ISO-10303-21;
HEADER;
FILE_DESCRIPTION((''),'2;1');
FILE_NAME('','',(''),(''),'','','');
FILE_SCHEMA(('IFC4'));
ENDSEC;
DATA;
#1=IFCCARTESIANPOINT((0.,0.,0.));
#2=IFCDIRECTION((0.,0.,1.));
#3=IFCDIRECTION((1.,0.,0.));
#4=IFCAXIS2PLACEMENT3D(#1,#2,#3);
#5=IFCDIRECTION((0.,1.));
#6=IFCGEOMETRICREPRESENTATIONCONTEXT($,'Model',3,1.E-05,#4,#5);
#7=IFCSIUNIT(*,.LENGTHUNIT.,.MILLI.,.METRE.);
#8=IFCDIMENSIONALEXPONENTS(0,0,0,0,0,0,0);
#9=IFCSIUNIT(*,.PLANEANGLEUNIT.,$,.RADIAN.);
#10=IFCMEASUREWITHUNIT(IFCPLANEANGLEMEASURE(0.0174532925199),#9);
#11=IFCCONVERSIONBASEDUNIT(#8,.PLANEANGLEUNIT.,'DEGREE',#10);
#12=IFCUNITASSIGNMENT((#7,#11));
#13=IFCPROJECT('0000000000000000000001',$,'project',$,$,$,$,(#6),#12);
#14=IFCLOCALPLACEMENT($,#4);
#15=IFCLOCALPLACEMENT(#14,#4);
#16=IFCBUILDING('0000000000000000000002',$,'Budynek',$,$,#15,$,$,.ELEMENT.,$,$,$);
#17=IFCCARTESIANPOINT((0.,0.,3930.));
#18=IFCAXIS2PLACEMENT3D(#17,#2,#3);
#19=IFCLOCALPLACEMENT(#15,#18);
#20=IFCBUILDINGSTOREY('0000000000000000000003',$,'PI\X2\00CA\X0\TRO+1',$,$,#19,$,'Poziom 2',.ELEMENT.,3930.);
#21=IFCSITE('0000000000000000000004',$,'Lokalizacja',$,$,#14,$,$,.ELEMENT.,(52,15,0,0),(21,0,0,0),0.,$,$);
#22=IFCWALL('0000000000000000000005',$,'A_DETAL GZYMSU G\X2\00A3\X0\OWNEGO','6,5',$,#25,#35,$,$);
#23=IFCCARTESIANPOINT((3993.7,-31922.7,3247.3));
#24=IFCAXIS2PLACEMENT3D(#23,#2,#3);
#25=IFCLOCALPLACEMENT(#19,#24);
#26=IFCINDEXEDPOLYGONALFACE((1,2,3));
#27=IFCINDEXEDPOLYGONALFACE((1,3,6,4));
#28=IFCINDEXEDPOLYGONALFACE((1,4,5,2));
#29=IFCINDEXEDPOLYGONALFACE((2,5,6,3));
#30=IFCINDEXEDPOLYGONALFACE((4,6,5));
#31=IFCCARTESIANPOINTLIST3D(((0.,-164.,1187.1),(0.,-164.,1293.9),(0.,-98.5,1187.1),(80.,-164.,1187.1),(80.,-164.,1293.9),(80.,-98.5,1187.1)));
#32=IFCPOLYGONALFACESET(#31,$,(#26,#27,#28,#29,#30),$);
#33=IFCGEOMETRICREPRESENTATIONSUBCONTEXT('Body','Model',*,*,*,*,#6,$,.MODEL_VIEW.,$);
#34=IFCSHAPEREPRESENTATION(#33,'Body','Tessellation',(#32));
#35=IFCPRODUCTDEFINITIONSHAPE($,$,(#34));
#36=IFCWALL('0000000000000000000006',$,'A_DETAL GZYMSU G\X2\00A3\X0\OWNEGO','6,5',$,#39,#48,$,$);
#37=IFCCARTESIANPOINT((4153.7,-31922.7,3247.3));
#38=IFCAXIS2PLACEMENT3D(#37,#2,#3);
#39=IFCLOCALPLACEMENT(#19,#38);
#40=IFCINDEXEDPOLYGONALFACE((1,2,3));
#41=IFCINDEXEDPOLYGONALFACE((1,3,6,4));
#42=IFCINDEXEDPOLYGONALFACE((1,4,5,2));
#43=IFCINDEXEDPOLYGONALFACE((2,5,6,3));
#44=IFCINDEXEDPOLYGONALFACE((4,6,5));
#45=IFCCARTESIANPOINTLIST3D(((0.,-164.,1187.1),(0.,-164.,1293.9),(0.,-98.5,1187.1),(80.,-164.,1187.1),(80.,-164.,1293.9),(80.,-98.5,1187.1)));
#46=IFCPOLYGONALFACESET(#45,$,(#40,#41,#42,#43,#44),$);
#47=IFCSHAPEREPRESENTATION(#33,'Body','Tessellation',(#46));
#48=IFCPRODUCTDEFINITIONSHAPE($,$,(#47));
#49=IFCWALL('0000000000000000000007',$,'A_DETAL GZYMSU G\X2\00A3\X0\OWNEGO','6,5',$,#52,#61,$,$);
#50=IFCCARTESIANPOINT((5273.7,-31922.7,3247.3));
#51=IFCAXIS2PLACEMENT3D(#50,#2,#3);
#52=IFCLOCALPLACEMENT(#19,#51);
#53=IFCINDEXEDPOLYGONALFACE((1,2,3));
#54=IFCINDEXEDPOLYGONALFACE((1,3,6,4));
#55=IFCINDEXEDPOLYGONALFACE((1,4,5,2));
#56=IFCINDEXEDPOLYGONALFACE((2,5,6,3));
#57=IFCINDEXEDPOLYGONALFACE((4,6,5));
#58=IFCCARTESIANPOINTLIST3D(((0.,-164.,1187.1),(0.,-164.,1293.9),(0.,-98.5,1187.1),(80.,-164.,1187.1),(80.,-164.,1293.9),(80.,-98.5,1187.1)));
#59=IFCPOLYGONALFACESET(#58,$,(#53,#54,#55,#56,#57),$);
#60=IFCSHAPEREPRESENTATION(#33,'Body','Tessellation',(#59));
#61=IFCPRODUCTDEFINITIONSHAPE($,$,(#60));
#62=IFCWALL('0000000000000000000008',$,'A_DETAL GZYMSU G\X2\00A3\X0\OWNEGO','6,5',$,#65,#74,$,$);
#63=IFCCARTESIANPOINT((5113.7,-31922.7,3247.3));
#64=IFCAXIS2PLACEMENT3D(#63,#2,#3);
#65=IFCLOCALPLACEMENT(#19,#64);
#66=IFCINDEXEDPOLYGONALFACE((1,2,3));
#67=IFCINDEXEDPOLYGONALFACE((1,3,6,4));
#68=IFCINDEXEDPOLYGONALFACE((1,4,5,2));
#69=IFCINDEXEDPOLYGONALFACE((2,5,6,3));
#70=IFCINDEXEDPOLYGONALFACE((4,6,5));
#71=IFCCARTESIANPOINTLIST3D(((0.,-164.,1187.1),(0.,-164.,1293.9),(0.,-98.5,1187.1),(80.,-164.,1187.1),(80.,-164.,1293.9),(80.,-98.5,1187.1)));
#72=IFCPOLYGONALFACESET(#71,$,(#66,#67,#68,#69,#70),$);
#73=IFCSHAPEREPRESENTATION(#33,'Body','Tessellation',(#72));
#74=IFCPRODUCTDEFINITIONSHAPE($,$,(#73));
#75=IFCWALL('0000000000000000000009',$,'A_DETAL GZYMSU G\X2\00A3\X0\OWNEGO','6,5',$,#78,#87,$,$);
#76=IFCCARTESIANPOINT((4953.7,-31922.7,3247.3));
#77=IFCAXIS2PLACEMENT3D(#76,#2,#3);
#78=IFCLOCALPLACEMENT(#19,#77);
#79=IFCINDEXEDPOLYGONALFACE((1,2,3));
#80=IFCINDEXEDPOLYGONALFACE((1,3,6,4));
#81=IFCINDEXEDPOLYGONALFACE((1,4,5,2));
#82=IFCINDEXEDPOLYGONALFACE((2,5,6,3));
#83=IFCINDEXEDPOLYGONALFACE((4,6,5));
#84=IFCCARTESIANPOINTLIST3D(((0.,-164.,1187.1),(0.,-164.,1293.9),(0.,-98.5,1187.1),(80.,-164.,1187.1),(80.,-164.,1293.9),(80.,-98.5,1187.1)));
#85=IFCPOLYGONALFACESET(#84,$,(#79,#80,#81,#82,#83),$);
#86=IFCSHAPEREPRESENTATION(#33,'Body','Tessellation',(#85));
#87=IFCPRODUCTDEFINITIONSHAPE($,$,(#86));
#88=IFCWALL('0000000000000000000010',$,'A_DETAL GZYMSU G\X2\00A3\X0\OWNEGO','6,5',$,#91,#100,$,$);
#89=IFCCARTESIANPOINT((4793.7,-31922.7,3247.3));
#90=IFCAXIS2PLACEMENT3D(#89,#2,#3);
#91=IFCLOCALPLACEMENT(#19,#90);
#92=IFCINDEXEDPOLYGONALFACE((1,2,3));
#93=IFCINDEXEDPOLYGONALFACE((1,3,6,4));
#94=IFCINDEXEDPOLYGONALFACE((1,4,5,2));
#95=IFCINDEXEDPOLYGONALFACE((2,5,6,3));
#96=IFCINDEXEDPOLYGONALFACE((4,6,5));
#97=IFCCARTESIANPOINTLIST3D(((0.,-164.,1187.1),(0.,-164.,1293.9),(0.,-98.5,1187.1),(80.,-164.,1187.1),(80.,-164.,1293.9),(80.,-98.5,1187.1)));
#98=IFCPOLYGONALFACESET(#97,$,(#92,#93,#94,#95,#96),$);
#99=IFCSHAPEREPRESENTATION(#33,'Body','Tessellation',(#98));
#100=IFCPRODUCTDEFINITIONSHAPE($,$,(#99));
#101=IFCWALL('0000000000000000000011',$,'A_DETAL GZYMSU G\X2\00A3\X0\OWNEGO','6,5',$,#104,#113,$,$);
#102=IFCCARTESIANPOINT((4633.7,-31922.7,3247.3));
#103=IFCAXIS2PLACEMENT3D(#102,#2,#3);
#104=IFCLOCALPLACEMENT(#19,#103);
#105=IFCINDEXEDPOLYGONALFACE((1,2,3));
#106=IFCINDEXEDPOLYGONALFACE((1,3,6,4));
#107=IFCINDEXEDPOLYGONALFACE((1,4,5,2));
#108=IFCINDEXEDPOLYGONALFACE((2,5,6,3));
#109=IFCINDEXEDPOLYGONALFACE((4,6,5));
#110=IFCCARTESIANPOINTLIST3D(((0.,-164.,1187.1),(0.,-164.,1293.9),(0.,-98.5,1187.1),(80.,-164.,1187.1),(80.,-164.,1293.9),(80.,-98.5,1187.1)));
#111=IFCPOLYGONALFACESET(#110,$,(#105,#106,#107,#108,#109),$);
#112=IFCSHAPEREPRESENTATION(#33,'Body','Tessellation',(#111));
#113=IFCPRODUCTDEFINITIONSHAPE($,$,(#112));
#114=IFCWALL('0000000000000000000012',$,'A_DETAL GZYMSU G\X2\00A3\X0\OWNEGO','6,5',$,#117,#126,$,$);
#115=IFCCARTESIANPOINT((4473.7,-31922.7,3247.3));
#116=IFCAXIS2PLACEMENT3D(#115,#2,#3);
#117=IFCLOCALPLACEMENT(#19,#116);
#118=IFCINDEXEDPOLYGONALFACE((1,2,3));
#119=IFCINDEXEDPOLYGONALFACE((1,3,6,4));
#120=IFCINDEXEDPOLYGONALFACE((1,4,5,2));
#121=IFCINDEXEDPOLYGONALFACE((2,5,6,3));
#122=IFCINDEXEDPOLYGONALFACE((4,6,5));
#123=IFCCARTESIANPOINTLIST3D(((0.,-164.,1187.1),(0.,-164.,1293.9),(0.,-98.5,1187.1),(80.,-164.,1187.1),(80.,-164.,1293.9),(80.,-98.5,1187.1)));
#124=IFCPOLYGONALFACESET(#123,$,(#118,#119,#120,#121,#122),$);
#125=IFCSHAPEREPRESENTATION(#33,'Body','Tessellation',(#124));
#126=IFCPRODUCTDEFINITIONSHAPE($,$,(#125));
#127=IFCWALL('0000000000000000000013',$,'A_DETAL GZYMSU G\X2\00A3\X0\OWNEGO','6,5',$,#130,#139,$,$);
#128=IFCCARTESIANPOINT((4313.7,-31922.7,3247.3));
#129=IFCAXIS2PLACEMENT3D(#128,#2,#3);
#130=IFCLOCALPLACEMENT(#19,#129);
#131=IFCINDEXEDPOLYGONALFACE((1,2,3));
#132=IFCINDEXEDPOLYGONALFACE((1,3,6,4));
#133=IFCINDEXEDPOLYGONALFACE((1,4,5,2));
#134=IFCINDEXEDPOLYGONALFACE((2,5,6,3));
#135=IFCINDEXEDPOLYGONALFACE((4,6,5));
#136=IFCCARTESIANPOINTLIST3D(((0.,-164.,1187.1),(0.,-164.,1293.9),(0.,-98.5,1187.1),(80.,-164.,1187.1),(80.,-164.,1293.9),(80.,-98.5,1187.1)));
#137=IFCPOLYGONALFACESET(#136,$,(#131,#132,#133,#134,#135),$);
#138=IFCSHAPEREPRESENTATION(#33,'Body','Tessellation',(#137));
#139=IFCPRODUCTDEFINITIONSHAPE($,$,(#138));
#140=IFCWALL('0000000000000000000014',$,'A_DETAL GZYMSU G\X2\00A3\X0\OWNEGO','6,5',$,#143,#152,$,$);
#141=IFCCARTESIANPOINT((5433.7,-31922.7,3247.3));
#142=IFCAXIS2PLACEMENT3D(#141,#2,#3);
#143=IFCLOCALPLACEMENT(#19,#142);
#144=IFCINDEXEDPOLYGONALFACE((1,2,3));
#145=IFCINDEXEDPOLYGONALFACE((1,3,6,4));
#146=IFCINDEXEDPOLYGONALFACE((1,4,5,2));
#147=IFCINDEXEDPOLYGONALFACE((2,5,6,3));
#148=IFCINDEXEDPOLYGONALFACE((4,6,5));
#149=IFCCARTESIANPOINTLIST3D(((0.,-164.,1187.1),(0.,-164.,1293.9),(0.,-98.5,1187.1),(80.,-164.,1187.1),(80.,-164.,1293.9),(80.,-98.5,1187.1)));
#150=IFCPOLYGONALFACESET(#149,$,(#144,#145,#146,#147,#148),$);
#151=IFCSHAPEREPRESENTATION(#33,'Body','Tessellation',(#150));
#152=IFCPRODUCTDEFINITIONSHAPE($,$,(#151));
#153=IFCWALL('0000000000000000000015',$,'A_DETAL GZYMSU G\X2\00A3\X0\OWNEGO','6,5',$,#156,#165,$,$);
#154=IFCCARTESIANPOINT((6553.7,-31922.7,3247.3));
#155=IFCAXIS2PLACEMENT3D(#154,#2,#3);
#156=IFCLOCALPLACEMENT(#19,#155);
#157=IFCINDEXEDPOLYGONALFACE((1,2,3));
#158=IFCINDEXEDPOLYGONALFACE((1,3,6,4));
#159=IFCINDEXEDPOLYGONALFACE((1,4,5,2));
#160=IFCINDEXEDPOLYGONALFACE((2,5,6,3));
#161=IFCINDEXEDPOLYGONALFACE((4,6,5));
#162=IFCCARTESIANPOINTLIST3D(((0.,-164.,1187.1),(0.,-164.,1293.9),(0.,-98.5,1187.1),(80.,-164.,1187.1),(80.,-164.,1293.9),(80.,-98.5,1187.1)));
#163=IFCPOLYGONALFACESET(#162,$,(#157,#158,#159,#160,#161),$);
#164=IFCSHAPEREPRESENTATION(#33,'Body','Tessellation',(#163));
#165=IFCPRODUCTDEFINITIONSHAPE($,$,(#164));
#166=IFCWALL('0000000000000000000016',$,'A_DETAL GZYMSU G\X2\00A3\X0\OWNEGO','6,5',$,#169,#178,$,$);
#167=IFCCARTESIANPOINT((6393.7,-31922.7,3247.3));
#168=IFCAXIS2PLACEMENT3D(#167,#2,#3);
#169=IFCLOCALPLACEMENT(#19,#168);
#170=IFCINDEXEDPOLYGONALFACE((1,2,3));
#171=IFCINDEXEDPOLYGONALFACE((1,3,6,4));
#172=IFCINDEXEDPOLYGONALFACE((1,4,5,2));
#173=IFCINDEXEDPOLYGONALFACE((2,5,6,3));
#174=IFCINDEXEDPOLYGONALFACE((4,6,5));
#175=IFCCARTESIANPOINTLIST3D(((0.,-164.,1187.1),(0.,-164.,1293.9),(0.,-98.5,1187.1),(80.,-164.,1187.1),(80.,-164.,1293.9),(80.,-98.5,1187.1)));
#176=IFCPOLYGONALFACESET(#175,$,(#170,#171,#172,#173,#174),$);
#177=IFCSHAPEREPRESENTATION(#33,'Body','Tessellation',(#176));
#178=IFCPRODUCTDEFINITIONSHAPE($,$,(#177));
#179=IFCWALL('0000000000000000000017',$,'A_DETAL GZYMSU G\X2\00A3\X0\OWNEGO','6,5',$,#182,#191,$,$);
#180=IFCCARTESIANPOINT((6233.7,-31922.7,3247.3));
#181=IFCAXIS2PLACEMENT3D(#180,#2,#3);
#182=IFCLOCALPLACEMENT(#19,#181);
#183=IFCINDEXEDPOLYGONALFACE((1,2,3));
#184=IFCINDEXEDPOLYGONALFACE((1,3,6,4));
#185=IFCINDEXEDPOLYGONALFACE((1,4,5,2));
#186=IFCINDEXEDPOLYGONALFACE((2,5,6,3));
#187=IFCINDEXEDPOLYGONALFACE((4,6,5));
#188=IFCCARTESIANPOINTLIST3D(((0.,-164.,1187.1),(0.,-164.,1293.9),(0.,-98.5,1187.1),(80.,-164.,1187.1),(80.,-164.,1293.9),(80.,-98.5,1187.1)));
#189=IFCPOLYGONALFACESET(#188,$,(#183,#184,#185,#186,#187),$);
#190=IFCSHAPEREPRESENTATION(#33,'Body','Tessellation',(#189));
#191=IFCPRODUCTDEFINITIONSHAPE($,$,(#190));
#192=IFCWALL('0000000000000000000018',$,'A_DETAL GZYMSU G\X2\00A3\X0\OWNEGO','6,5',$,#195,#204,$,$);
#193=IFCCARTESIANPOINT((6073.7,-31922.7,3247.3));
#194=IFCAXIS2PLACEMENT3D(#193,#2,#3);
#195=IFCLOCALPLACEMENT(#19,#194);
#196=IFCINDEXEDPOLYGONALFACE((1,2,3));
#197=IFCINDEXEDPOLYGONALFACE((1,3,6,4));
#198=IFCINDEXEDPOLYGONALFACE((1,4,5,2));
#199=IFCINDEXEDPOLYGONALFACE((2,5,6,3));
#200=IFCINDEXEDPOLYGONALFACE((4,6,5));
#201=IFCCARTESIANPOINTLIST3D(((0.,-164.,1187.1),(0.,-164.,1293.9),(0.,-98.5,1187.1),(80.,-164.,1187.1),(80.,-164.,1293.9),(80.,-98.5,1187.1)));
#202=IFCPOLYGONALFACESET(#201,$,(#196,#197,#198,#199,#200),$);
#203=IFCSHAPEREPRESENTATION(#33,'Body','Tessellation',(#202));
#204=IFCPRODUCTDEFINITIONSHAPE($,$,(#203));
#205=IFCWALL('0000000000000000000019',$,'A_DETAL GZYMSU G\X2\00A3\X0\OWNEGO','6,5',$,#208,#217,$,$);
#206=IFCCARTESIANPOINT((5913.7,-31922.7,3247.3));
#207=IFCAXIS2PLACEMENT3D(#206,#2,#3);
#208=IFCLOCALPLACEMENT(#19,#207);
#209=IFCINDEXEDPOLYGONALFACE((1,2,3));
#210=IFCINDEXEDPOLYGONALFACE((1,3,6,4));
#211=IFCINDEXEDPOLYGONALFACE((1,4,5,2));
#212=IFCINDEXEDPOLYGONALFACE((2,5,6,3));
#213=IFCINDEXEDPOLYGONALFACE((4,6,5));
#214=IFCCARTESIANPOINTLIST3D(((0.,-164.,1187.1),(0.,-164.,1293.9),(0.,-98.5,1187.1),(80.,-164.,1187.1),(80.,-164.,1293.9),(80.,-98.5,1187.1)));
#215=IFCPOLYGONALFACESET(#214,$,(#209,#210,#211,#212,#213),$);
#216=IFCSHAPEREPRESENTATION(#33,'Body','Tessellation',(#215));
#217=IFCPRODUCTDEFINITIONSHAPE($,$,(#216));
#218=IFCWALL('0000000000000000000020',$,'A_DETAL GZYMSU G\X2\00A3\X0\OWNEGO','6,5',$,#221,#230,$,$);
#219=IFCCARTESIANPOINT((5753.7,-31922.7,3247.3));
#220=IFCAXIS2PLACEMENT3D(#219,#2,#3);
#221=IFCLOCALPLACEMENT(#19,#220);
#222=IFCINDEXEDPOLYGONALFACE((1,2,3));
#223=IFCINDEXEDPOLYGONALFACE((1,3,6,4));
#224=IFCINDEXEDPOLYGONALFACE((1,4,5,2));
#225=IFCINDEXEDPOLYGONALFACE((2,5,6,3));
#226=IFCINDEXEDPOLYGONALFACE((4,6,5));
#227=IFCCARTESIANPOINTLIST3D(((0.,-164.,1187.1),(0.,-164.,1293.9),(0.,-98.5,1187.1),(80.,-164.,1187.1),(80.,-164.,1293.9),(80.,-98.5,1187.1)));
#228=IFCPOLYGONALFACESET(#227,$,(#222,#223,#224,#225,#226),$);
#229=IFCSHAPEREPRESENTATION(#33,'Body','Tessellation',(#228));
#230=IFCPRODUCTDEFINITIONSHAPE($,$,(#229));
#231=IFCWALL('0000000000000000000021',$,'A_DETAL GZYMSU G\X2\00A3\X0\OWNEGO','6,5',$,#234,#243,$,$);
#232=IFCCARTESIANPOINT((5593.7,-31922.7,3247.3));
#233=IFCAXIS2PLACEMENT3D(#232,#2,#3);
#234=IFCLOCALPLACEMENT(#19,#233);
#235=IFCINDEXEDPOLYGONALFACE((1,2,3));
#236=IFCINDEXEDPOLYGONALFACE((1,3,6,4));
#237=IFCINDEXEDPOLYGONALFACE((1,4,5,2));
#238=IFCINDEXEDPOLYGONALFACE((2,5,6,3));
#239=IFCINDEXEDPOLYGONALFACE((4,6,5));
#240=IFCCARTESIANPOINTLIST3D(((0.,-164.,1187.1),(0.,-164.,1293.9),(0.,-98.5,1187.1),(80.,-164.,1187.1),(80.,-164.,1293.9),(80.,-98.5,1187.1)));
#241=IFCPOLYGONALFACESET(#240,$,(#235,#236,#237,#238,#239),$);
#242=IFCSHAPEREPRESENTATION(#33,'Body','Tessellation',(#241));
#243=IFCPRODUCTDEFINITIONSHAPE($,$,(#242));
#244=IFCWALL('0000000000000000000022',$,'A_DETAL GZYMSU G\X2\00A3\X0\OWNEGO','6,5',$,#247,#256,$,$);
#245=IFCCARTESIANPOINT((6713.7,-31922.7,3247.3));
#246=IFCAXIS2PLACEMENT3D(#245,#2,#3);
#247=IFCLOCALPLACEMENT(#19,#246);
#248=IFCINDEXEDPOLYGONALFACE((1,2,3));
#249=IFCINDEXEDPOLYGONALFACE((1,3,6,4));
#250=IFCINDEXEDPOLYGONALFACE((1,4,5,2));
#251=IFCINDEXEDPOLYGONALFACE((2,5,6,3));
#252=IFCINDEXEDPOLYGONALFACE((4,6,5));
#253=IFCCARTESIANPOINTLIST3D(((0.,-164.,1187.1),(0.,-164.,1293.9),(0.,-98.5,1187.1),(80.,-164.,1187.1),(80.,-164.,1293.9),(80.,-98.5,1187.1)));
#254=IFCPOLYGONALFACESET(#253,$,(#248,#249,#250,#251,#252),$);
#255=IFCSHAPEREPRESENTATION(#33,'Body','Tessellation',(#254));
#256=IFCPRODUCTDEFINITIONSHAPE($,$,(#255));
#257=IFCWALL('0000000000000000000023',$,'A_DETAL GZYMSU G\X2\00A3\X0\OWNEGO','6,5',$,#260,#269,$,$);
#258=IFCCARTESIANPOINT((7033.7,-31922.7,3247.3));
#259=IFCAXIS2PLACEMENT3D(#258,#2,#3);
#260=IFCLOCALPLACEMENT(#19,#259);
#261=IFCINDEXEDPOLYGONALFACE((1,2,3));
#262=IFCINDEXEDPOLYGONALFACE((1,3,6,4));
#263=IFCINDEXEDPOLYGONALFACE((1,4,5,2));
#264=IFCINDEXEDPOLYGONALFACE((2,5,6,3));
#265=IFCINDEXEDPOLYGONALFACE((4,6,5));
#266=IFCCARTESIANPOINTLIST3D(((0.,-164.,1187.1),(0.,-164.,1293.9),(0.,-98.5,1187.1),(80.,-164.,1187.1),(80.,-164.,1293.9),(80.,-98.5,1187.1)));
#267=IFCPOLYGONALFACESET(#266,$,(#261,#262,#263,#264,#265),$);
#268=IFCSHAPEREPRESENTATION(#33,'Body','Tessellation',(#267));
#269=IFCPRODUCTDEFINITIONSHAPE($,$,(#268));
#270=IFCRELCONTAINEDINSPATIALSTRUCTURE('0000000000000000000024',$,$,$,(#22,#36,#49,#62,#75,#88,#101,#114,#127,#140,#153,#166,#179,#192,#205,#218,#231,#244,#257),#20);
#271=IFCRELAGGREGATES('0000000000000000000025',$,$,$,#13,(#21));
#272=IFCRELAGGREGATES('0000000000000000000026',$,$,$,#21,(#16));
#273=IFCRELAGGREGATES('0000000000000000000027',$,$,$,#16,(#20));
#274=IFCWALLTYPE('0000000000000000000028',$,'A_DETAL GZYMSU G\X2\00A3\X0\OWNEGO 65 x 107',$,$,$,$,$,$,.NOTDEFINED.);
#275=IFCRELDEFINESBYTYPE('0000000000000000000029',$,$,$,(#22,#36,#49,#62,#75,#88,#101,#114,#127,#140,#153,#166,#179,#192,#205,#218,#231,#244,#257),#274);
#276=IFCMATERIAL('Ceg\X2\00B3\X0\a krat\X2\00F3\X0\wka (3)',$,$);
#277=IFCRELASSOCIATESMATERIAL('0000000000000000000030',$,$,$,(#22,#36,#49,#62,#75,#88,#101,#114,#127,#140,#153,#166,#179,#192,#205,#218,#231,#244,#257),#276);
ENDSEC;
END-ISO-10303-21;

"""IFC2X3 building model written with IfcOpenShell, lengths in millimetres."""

from ifc_helpers import new_model, entity, si_unit, converted_unit, direction, frame, origin_with_axes, place, context, subcontext, project, spatial, polyline, outline, extrude, material, type_object, element, save


model = new_model("IFC2X3")

# Units and contexts
model_context = context("Model", 3, precision=1e-05, world=origin_with_axes(), true_north=direction((0.0, 1.0)))
body_context = subcontext(model_context, "Body", "Model", "MODEL_VIEW")
ifc_project = project(units=[si_unit("LENGTHUNIT", "METRE", prefix="MILLI"), converted_unit("PLANEANGLEUNIT", "DEGREE", entity("IfcPlaneAngleMeasure", 0.0174532925199), si_unit("PLANEANGLEUNIT", "RADIAN"), dimensions=[0, 0, 0, 0, 0, 0, 0])], contexts=[model_context])

# Site, building, storey
site_placement = place(None, origin_with_axes())
site = spatial("IfcSite", under=ifc_project, at=site_placement, Name="Lokalizacja", CompositionType="ELEMENT", RefLatitude=(52, 15, 0, 0), RefLongitude=(21, 0, 0, 0), RefElevation=0.0)
building_placement = place(site_placement, origin_with_axes())
building = spatial("IfcBuilding", under=site, at=building_placement, Name="Budynek", CompositionType="ELEMENT")
storey_placement = place(building_placement, frame((0.0, 0.0, 3930.0), z_axis=(0.0, 0.0, 1.0), x_axis=(1.0, 0.0, 0.0)))
storey = spatial("IfcBuildingStorey", under=building, at=storey_placement, Name="PIÊTRO+1", LongName="Poziom 2", CompositionType="ELEMENT", Elevation=3930.0)

# Walls
ifc_material_1 = material(Name="Ceg³a kratówka (3)")
wall_type = type_object("IfcWallType", Name="A_DETAL GZYMSU G£OWNEGO 65 x 107", PredefinedType="NOTDEFINED")
for number, where, z_axis, x_axis, name in (
    (1, (3993.7, -31922.7, 3247.3), (0.0, 0.0, 1.0), (1.0, 0.0, 0.0), "A_DETAL GZYMSU G£OWNEGO"),
    (2, (4153.7, -31922.7, 3247.3), (0.0, 0.0, 1.0), (1.0, 0.0, 0.0), "A_DETAL GZYMSU G£OWNEGO"),
    (3, (5273.7, -31922.7, 3247.3), (0.0, 0.0, 1.0), (1.0, 0.0, 0.0), "A_DETAL GZYMSU G£OWNEGO"),
    (4, (5113.7, -31922.7, 3247.3), (0.0, 0.0, 1.0), (1.0, 0.0, 0.0), "A_DETAL GZYMSU G£OWNEGO"),
    (5, (4953.7, -31922.7, 3247.3), (0.0, 0.0, 1.0), (1.0, 0.0, 0.0), "A_DETAL GZYMSU G£OWNEGO"),
    (6, (4793.7, -31922.7, 3247.3), (0.0, 0.0, 1.0), (1.0, 0.0, 0.0), "A_DETAL GZYMSU G£OWNEGO"),
    (7, (4633.7, -31922.7, 3247.3), (0.0, 0.0, 1.0), (1.0, 0.0, 0.0), "A_DETAL GZYMSU G£OWNEGO"),
    (8, (4473.7, -31922.7, 3247.3), (0.0, 0.0, 1.0), (1.0, 0.0, 0.0), "A_DETAL GZYMSU G£OWNEGO"),
    (9, (4313.7, -31922.7, 3247.3), (0.0, 0.0, 1.0), (1.0, 0.0, 0.0), "A_DETAL GZYMSU G£OWNEGO"),
    (10, (5433.7, -31922.7, 3247.3), (0.0, 0.0, 1.0), (1.0, 0.0, 0.0), "A_DETAL GZYMSU G£OWNEGO"),
    (11, (6553.7, -31922.7, 3247.3), (0.0, 0.0, 1.0), (1.0, 0.0, 0.0), "A_DETAL GZYMSU G£OWNEGO"),
    (12, (6393.7, -31922.7, 3247.3), (0.0, 0.0, 1.0), (1.0, 0.0, 0.0), "A_DETAL GZYMSU G£OWNEGO"),
    (13, (6233.7, -31922.7, 3247.3), (0.0, 0.0, 1.0), (1.0, 0.0, 0.0), "A_DETAL GZYMSU G£OWNEGO"),
    (14, (6073.7, -31922.7, 3247.3), (0.0, 0.0, 1.0), (1.0, 0.0, 0.0), "A_DETAL GZYMSU G£OWNEGO"),
    (15, (5913.7, -31922.7, 3247.3), (0.0, 0.0, 1.0), (1.0, 0.0, 0.0), "A_DETAL GZYMSU G£OWNEGO"),
    (16, (5753.7, -31922.7, 3247.3), (0.0, 0.0, 1.0), (1.0, 0.0, 0.0), "A_DETAL GZYMSU G£OWNEGO"),
    (17, (5593.7, -31922.7, 3247.3), (0.0, 0.0, 1.0), (1.0, 0.0, 0.0), "A_DETAL GZYMSU G£OWNEGO"),
    (18, (6713.7, -31922.7, 3247.3), (0.0, 0.0, 1.0), (1.0, 0.0, 0.0), "A_DETAL GZYMSU G£OWNEGO"),
    (19, (7033.7, -31922.7, 3247.3), (0.0, 0.0, 1.0), (1.0, 0.0, 0.0), "A_DETAL GZYMSU G£OWNEGO"),
):
    element("IfcWall", number, at=place(storey_placement, frame(where, z_axis=z_axis, x_axis=x_axis)), inside=storey, type_object=wall_type, material=ifc_material_1, Name=name, Description="6,5", context=body_context, shape_type="SweptSolid", body=[
        extrude(outline(polyline([(-164.0, 1293.9), (-164.0, 1187.1), (-98.5, 1187.1), (-164.0, 1293.9)])), frame((0.0, 0.0, 0.0), z_axis=(1.0, 0.0, 0.0), x_axis=(0.0, 1.0, 0.0)), (0.0, 0.0, 1.0), 80.0),
    ])

save(model, "model.ifc")
